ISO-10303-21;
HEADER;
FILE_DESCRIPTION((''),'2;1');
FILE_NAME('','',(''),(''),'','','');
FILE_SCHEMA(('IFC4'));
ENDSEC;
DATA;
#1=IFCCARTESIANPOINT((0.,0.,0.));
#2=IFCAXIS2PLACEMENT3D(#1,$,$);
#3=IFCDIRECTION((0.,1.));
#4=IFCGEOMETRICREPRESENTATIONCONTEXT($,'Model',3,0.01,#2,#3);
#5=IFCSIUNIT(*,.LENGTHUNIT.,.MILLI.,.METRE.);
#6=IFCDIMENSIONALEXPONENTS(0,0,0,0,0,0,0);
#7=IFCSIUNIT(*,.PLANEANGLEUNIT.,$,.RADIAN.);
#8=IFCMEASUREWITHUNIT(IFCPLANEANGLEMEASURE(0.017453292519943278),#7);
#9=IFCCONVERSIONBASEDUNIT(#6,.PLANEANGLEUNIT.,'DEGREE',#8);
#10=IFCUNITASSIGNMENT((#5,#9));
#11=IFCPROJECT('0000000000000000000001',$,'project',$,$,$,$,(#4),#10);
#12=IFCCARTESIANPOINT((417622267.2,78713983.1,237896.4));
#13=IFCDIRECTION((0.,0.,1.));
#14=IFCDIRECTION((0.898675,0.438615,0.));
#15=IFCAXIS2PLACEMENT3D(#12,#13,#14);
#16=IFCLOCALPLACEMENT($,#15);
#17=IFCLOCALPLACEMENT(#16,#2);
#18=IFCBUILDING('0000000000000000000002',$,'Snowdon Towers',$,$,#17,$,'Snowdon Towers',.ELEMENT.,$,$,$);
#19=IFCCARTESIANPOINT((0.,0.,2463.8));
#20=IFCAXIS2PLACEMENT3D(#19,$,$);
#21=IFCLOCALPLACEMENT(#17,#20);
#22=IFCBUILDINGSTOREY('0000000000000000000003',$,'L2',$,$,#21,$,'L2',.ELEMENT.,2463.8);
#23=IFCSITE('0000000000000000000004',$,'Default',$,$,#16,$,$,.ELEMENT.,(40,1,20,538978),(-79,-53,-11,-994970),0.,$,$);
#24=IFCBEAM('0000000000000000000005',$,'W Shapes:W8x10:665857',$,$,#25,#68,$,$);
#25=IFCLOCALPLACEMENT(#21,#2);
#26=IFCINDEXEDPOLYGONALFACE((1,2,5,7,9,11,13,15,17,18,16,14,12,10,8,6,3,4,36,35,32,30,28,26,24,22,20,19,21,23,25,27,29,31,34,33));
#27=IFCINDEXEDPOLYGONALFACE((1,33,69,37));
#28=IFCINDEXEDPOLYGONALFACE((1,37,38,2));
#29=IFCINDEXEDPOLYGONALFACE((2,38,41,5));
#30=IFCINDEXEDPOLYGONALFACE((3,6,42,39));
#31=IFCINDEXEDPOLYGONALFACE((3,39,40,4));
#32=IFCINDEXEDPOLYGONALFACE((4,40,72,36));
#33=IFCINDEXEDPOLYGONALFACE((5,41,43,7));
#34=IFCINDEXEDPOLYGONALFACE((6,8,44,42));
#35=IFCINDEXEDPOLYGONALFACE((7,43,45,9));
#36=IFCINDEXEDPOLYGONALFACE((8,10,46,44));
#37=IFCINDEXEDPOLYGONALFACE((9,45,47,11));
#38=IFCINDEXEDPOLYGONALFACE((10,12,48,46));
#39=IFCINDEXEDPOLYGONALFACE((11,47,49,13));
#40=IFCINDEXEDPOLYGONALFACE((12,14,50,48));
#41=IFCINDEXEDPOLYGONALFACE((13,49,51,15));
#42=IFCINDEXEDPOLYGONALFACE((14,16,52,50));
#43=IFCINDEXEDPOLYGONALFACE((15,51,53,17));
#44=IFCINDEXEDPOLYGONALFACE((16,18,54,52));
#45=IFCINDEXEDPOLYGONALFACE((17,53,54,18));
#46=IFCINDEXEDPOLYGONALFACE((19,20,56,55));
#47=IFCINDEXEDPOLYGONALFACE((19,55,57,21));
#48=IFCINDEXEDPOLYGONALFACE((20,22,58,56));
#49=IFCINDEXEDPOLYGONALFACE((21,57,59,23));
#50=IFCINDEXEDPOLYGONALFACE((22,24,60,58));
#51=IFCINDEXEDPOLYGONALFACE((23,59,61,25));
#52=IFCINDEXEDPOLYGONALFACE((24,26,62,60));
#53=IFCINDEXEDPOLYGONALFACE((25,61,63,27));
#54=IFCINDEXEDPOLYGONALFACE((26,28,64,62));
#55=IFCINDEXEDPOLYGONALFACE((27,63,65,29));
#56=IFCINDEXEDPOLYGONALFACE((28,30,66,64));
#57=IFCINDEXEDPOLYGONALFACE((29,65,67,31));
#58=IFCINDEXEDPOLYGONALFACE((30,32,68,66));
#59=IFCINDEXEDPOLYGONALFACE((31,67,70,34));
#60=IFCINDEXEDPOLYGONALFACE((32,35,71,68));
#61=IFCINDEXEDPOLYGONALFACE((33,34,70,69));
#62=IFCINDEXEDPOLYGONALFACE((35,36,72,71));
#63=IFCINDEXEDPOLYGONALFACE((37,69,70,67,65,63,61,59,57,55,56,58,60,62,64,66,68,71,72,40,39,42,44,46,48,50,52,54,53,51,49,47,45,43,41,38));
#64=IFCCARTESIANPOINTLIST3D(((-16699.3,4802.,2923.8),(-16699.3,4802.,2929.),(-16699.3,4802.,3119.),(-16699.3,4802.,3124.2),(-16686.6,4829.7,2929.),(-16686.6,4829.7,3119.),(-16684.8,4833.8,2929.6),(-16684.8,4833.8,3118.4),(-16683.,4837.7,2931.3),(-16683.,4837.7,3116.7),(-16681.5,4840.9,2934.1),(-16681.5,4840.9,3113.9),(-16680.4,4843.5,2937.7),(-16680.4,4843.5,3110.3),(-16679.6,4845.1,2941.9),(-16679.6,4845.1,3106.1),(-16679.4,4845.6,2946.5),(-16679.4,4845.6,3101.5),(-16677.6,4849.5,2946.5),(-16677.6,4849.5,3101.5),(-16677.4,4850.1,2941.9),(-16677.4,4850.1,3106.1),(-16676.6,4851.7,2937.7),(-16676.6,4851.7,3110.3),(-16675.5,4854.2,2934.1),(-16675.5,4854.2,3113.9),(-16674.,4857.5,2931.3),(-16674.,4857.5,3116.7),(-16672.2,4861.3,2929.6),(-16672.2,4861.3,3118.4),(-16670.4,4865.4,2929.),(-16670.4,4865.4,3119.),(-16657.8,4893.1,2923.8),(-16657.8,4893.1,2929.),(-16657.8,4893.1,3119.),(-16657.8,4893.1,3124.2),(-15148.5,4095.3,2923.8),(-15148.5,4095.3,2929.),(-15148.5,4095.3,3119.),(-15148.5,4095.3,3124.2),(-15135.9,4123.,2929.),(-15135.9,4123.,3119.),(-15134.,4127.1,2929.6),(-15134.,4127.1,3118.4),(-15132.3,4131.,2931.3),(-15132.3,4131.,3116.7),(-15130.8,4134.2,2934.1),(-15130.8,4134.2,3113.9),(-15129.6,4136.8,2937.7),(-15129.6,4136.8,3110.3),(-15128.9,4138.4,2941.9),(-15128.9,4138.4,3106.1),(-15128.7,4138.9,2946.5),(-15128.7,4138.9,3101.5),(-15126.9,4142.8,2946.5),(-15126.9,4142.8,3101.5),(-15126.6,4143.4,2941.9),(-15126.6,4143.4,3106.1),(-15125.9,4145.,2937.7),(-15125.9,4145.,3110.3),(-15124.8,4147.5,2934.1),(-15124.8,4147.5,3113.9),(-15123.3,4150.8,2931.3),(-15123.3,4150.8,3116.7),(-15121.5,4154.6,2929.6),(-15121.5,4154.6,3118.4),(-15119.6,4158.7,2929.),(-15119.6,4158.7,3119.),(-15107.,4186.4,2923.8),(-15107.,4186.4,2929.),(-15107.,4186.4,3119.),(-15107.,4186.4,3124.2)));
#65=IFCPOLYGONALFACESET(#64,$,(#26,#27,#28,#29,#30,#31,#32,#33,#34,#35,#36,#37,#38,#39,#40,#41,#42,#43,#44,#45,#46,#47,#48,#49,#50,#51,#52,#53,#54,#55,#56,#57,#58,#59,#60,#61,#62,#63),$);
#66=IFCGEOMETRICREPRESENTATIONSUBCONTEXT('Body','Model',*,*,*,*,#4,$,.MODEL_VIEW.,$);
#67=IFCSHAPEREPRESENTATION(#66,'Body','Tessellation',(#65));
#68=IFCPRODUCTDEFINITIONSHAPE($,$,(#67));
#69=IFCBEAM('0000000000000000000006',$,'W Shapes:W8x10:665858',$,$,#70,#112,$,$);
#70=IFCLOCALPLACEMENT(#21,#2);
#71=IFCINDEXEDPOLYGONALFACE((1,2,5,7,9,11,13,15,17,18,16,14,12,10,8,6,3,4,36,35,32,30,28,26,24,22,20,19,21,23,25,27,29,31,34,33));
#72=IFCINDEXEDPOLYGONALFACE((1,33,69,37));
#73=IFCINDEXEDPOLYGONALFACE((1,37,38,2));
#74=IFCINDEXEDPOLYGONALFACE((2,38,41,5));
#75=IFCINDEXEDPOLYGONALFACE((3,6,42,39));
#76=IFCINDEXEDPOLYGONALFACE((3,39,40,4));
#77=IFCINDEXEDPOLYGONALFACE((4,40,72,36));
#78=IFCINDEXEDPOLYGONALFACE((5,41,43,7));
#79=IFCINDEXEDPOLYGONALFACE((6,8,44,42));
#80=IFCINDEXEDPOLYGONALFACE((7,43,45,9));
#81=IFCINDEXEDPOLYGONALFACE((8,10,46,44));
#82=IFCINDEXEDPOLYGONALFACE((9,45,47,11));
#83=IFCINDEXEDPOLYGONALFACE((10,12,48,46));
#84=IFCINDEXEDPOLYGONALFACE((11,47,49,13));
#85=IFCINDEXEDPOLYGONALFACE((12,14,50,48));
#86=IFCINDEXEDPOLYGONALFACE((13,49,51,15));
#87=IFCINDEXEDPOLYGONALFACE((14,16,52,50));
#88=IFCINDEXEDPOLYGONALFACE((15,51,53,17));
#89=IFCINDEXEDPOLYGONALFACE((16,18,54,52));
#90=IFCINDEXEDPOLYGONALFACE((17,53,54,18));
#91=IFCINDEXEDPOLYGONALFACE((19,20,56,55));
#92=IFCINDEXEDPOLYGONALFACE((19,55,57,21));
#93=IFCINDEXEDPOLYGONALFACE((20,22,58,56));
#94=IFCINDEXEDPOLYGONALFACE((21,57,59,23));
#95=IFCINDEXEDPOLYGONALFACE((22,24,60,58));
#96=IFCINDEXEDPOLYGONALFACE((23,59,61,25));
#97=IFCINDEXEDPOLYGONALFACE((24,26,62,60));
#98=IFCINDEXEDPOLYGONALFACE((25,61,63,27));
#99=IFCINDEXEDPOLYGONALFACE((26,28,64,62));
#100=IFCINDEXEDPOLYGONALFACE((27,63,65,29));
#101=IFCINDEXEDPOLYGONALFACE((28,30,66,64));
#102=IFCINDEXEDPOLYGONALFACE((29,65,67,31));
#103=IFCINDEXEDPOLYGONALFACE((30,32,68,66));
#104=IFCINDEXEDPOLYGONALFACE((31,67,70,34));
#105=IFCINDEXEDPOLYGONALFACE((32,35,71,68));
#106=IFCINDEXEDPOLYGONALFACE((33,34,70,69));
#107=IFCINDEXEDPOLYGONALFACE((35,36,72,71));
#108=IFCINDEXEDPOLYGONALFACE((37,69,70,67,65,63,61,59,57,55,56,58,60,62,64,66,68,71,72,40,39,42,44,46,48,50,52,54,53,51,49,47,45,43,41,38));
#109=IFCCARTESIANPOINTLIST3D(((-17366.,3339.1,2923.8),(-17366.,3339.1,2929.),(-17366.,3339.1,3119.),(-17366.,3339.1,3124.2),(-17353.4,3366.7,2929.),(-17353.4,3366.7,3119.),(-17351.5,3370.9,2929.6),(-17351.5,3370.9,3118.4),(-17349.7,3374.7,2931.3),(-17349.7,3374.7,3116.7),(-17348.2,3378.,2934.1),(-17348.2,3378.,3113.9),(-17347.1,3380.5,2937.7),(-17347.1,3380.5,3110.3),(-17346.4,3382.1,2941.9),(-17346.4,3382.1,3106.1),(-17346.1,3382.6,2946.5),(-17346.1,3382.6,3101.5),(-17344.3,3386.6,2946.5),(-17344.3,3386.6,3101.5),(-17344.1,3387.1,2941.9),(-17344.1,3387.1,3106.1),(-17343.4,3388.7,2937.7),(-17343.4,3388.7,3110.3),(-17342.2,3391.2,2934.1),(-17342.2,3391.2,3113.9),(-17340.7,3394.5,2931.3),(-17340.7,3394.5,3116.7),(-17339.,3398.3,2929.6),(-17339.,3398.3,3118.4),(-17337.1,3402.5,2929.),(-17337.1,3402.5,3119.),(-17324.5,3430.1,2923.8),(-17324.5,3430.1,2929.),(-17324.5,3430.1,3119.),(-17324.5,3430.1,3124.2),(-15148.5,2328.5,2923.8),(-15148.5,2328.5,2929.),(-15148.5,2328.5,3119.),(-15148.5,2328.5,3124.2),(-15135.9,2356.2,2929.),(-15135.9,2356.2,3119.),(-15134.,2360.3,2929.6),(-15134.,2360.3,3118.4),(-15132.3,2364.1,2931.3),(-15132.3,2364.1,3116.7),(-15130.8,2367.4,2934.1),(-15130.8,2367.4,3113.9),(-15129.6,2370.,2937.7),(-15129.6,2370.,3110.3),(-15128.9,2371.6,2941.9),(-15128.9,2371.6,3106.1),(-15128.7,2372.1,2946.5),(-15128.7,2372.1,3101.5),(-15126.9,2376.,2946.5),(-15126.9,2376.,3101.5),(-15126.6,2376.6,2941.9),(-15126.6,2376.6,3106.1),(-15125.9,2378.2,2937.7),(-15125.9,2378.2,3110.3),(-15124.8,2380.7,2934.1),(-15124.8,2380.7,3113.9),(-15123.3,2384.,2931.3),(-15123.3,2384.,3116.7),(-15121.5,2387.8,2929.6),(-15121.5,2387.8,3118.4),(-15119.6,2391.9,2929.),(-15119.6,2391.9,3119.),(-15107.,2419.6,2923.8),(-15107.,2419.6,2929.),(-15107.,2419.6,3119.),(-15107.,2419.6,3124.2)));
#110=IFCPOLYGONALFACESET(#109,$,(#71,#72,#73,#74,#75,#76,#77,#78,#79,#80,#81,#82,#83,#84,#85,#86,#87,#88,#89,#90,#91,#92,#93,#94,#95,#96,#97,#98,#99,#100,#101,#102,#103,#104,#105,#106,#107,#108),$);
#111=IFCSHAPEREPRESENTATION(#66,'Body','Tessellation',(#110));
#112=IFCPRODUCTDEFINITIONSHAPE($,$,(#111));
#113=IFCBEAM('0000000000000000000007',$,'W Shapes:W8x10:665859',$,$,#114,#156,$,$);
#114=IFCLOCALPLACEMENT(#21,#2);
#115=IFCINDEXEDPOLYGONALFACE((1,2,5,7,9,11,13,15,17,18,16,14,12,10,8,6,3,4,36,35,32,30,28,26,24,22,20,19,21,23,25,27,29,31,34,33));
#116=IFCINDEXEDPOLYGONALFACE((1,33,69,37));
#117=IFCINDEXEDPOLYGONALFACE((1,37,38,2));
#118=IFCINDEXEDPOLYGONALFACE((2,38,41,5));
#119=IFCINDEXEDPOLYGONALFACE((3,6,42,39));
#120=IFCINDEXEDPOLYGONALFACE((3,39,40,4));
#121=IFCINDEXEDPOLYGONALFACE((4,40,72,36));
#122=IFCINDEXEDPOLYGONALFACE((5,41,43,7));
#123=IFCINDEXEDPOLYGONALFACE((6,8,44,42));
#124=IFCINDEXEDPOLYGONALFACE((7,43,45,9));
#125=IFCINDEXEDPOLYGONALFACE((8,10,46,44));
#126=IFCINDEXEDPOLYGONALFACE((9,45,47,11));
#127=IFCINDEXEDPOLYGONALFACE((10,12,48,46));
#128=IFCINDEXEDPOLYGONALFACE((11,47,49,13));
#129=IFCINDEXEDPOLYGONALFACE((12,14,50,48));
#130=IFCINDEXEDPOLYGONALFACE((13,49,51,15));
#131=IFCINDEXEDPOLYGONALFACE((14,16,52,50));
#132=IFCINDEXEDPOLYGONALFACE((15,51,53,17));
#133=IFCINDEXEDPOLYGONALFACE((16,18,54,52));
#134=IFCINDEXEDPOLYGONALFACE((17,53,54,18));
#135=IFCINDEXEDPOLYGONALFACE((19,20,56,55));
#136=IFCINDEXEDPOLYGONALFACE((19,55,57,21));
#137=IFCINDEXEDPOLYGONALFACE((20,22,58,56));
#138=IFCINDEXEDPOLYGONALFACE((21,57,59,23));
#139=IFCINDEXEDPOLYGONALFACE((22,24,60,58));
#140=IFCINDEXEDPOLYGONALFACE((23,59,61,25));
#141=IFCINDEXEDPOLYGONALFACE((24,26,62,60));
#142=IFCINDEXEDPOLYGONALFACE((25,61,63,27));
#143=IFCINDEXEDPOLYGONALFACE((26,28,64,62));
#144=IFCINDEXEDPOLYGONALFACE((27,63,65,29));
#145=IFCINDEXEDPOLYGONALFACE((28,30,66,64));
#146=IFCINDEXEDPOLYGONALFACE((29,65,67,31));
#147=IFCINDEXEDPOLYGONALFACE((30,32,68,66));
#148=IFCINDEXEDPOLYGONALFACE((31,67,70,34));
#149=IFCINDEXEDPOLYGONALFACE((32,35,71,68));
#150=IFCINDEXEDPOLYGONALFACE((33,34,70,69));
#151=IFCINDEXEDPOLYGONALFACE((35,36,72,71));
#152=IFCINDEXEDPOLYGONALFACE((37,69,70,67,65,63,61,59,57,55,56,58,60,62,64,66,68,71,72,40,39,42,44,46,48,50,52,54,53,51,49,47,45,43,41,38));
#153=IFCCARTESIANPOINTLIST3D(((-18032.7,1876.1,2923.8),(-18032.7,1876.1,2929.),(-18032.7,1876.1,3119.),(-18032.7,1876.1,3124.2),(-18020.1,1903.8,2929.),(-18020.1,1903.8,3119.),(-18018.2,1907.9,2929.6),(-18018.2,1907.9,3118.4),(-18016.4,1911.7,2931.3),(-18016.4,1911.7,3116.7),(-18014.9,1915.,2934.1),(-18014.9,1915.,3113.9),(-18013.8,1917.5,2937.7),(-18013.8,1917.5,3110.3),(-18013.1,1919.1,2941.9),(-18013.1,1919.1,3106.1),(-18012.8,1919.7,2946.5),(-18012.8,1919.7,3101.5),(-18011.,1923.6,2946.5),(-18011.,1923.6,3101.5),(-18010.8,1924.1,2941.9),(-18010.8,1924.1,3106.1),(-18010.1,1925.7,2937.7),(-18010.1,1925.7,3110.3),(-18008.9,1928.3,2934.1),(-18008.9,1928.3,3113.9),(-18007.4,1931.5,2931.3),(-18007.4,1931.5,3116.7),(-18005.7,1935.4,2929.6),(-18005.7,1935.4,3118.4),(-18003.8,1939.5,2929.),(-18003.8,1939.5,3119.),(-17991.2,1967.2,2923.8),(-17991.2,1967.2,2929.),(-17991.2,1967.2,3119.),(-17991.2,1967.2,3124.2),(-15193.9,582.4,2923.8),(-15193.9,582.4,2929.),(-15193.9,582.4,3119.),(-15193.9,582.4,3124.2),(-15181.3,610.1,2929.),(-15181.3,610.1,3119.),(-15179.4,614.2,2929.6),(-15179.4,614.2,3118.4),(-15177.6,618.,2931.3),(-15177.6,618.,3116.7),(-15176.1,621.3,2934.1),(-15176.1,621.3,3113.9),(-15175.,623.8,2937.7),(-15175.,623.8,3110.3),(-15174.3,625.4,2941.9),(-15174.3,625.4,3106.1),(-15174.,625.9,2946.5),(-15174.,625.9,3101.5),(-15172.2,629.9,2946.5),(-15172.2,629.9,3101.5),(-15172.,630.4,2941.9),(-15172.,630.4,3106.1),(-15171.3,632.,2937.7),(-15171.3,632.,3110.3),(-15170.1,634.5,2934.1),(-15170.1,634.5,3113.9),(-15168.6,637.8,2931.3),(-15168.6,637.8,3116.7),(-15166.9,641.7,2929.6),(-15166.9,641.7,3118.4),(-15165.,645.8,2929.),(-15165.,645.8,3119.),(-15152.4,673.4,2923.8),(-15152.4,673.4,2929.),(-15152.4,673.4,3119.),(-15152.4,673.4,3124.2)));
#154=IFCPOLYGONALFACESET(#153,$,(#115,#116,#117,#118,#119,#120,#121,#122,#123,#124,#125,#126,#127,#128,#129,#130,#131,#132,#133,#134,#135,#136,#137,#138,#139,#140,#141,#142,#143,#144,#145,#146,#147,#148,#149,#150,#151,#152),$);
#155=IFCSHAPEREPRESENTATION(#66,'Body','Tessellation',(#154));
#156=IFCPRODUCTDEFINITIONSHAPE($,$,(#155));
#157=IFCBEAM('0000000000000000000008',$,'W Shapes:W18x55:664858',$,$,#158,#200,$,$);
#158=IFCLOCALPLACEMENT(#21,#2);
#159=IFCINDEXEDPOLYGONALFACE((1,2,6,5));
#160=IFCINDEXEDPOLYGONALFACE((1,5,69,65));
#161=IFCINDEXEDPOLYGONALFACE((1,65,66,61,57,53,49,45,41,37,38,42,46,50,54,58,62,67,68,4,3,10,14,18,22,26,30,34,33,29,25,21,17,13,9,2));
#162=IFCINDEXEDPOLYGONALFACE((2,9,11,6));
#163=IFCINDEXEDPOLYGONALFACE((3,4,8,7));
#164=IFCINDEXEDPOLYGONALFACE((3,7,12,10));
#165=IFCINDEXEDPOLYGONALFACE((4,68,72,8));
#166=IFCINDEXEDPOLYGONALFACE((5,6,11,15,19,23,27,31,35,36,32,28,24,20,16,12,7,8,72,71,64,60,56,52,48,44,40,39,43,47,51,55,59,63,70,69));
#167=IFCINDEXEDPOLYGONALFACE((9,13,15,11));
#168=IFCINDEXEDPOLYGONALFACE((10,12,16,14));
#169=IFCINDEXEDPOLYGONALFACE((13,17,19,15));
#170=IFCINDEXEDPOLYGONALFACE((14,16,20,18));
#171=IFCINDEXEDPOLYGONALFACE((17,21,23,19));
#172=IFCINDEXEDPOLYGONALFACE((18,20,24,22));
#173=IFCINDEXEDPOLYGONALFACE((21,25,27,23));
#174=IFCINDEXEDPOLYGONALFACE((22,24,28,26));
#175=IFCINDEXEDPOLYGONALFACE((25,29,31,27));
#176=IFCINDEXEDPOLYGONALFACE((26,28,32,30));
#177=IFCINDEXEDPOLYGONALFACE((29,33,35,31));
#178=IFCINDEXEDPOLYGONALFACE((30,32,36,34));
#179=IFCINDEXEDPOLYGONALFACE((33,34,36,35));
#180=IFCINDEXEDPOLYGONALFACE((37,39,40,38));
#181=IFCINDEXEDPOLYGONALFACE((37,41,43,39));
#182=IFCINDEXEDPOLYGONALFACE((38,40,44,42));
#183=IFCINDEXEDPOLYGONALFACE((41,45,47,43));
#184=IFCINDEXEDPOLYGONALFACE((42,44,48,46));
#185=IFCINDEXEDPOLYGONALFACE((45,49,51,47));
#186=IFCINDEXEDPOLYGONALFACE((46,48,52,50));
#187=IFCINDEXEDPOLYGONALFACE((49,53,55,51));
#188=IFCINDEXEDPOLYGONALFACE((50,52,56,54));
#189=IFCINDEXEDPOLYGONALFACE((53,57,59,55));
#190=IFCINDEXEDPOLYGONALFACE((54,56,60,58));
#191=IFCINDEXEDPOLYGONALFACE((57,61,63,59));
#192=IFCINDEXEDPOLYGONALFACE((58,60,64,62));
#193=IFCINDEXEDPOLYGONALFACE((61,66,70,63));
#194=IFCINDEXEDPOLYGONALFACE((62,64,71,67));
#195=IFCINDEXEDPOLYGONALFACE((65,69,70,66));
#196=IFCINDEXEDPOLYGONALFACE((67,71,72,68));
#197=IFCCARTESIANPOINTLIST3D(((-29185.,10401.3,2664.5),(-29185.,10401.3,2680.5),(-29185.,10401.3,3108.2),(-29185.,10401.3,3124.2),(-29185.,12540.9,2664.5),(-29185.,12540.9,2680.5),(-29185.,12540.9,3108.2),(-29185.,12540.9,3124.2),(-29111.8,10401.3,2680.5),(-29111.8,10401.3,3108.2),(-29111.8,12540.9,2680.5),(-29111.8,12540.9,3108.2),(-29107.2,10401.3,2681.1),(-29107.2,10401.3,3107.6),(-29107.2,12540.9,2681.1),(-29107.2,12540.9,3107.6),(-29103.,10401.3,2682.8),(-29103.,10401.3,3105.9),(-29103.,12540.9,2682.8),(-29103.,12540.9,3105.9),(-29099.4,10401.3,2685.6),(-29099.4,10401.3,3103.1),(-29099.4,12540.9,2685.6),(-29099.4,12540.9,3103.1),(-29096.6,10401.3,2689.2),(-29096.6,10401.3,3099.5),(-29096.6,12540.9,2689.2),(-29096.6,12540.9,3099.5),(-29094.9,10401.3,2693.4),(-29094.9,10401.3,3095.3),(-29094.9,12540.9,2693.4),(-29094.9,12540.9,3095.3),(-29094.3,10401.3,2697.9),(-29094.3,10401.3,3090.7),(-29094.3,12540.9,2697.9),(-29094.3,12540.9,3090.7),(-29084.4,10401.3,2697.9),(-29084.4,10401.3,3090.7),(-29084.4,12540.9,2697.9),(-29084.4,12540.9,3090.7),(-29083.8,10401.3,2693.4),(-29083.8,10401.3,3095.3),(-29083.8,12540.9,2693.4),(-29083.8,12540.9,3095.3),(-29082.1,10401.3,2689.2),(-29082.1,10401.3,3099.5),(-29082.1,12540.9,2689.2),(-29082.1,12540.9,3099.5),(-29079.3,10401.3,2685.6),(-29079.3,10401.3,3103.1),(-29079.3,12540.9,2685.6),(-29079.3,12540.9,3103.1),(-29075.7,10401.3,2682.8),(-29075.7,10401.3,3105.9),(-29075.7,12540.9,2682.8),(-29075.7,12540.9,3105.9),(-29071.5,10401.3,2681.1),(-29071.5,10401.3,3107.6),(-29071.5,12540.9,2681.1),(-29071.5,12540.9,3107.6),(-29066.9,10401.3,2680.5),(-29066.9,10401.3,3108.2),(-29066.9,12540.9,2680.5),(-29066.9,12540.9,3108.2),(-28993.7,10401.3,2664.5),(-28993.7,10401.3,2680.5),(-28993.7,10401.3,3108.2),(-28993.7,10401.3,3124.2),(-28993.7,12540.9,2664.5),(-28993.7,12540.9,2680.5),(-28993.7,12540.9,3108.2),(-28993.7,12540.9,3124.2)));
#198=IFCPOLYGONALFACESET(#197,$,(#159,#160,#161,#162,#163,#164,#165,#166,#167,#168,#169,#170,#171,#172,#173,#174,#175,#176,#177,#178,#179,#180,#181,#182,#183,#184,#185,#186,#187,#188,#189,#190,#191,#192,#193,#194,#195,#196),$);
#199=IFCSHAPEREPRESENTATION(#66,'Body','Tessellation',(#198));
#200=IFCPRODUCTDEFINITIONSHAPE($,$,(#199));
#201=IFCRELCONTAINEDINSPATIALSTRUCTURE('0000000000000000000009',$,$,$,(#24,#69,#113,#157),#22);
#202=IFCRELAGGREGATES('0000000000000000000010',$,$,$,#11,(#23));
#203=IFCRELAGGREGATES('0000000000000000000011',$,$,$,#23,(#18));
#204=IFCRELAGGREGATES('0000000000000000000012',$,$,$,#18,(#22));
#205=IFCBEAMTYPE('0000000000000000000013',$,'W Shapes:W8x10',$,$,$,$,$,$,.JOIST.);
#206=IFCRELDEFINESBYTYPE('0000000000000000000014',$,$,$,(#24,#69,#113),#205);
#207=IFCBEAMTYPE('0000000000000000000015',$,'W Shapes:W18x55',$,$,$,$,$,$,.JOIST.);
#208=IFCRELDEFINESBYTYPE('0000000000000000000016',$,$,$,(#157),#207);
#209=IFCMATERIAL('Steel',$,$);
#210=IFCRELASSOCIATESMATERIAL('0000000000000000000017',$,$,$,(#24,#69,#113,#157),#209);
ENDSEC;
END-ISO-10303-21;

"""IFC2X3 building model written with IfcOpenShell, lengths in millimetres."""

from ifc_helpers import new_model, entity, si_unit, converted_unit, direction, frame, frame_2d, origin, place, context, subcontext, project, spatial, i_section, extrude, material, type_object, element, save


model = new_model("IFC2X3")

# Units and contexts
model_context = context("Model", 3, precision=0.01, world=origin(), true_north=direction((0.0, 1.0)))
body_context = subcontext(model_context, "Body", "Model", "MODEL_VIEW")
ifc_project = project(units=[si_unit("LENGTHUNIT", "METRE", prefix="MILLI"), converted_unit("PLANEANGLEUNIT", "DEGREE", entity("IfcPlaneAngleMeasure", 0.017453292519943278), si_unit("PLANEANGLEUNIT", "RADIAN"), dimensions=[0, 0, 0, 0, 0, 0, 0])], contexts=[model_context])

# Site, building, storey
site_placement = place(None, frame((417622267.2, 78713983.1, 237896.4), z_axis=(0.0, 0.0, 1.0), x_axis=(0.898675, 0.438615, 0.0)))
site = spatial("IfcSite", under=ifc_project, at=site_placement, Name="Default", CompositionType="ELEMENT", RefLatitude=(40, 1, 20, 538978), RefLongitude=(-79, -53, -11, -994970), RefElevation=0.0)
building_placement = place(site_placement, origin())
building = spatial("IfcBuilding", under=site, at=building_placement, Name="Snowdon Towers", LongName="Snowdon Towers", CompositionType="ELEMENT")
storey_placement = place(building_placement, frame((0.0, 0.0, 2463.8)))
storey = spatial("IfcBuildingStorey", under=building, at=storey_placement, Name="L2", LongName="L2", CompositionType="ELEMENT", Elevation=2463.8)

# Beams
ifc_material_1 = material(Name="Steel")
beam_type_1 = type_object("IfcBeamType", Name="W Shapes:W8x10", PredefinedType="JOIST")
beam_1_placement = place(storey_placement, frame((-16806.8, 4906.0, 3124.2), z_axis=(0.0, 0.0, 1.0), x_axis=(0.909961, -0.414693, 0.0)))
element("IfcBeam", 1, at=beam_1_placement, inside=storey, type_object=beam_type_1, material=ifc_material_1, Name="W Shapes:W8x10:665857", context=body_context, shape_type="SweptSolid", body=[
    extrude(i_section(OverallWidth=100.1, OverallDepth=200.4, WebThickness=4.3, FlangeThickness=5.2, FilletRadius=17.5, at=frame_2d((0.0, 0.0), x_axis=(0.0, 1.0))), frame((141.0, 0.0, -100.2), z_axis=(1.0, 0.0, 0.0), x_axis=(0.0, 0.0, -1.0)), (0.0, 0.0, 1.0), 1704.2),
])
beam_2_placement = place(storey_placement, frame((-17473.5, 3443.1, 3124.2), z_axis=(0.0, 0.0, 1.0), x_axis=(0.909961, -0.414693, 0.0)))
element("IfcBeam", 2, at=beam_2_placement, inside=storey, type_object=beam_type_1, material=ifc_material_1, Name="W Shapes:W8x10:665858", context=body_context, shape_type="SweptSolid", body=[
    extrude(i_section(OverallWidth=100.1, OverallDepth=200.4, WebThickness=4.3, FlangeThickness=5.2, FilletRadius=17.5, at=frame_2d((0.0, 0.0), x_axis=(0.0, 1.0))), frame((141.0, 0.0, -100.2), z_axis=(1.0, 0.0, 0.0), x_axis=(0.0, 0.0, -1.0)), (0.0, 0.0, 1.0), 2436.8),
])
beam_3_placement = place(storey_placement, frame((-18140.2, 1980.1, 3124.2), z_axis=(0.0, 0.0, 1.0), x_axis=(0.909961, -0.414693, 0.0)))
element("IfcBeam", 3, at=beam_3_placement, inside=storey, type_object=beam_type_1, material=ifc_material_1, Name="W Shapes:W8x10:665859", context=body_context, shape_type="SweptSolid", body=[
    extrude(i_section(OverallWidth=100.1, OverallDepth=200.4, WebThickness=4.3, FlangeThickness=5.2, FilletRadius=17.5, at=frame_2d((0.0, 0.0), x_axis=(0.0, 1.0))), frame((141.0, 0.0, -100.2), z_axis=(1.0, 0.0, 0.0), x_axis=(0.0, 0.0, -1.0)), (0.0, 0.0, 1.0), 3119.7),
])
beam_type_2 = type_object("IfcBeamType", Name="W Shapes:W18x55", PredefinedType="JOIST")
beam_4_placement = place(storey_placement, frame((-29089.3, 12636.5, 3124.2), z_axis=(0.0, 0.0, 1.0), x_axis=(0.0, -1.0, 0.0)))
element("IfcBeam", 4, at=beam_4_placement, inside=storey, type_object=beam_type_2, material=ifc_material_1, Name="W Shapes:W18x55:664858", context=body_context, shape_type="SweptSolid", body=[
    extrude(i_section(OverallWidth=191.3, OverallDepth=459.7, WebThickness=9.9, FlangeThickness=16.0, FilletRadius=17.5, at=frame_2d((0.0, 0.0), x_axis=(0.0, 1.0))), frame((95.6, 0.0, -229.9), z_axis=(1.0, 0.0, 0.0), x_axis=(0.0, 0.0, -1.0)), (0.0, 0.0, 1.0), 2139.6),
])

save(model, "model.ifc")
